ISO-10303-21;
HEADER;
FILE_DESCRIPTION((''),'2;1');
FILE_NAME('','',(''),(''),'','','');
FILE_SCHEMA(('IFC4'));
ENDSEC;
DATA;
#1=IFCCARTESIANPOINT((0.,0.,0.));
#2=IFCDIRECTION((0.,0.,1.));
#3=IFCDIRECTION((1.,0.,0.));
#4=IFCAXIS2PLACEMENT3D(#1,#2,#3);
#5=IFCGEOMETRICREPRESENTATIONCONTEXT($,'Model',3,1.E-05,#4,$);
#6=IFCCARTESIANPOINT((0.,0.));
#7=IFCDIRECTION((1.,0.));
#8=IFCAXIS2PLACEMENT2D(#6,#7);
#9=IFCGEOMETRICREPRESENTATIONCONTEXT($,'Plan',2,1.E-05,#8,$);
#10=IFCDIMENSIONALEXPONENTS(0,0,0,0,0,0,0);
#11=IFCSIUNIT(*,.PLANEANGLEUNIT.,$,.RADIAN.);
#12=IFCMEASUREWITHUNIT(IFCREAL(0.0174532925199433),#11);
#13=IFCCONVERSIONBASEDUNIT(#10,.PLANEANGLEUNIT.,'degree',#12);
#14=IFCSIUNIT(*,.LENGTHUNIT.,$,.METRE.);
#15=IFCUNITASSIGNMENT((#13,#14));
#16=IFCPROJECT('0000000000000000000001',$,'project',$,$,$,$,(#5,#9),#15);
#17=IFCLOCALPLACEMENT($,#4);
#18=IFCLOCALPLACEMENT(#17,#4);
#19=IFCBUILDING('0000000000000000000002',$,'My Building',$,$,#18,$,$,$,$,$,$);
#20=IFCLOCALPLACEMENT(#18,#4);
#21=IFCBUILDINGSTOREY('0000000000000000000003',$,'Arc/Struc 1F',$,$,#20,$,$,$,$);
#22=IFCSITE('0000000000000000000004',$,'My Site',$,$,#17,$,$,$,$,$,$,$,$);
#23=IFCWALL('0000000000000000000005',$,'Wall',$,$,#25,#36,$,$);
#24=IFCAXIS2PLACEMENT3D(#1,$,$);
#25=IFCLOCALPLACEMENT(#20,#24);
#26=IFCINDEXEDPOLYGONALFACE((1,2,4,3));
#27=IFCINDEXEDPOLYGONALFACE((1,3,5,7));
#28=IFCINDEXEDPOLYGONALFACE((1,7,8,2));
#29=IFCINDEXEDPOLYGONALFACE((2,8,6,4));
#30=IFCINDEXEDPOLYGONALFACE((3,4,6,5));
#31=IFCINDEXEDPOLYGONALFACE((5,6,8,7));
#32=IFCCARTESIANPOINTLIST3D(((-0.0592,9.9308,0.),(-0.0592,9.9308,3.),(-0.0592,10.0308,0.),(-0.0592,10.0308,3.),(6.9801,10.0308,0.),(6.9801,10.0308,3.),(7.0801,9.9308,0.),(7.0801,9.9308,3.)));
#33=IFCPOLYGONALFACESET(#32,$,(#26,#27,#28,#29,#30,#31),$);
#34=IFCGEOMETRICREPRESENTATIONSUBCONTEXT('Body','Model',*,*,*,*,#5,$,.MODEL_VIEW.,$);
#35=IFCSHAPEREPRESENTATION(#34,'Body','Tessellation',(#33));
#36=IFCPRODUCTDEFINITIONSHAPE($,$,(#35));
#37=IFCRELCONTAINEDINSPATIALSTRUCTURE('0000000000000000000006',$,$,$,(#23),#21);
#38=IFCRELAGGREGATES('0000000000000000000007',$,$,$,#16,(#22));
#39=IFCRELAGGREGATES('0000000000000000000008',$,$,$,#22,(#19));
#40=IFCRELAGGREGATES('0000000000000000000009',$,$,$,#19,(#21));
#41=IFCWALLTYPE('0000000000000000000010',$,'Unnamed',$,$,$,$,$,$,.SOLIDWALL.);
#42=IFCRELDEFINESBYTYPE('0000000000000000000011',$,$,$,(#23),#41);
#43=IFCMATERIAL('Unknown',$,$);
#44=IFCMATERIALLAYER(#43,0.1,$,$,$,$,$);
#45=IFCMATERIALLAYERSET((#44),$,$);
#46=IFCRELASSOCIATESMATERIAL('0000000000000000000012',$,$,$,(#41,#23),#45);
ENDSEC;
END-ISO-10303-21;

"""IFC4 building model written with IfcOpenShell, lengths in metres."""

from ifc_helpers import new_model, entity, si_unit, converted_unit, frame, origin_with_axes, origin_2d_with_axis, place, context, subcontext, project, spatial, line, indexed_curve, outline, extrude, material, layer, layer_set, layer_usage, type_object, element, save


model = new_model("IFC4")

# Units and contexts
model_context = context("Model", 3, precision=1e-05, world=origin_with_axes())
plan_context = context("Plan", 2, precision=1e-05, world=origin_2d_with_axis())
body_context_1 = subcontext(model_context, "Body", "Model", "MODEL_VIEW")
ifc_project = project(units=[converted_unit("PLANEANGLEUNIT", "degree", entity("IfcReal", 0.0174532925199433), si_unit("PLANEANGLEUNIT", "RADIAN"), dimensions=[0, 0, 0, 0, 0, 0, 0]), si_unit("LENGTHUNIT", "METRE")], contexts=[model_context, plan_context])

# Site, building, storey
site_placement = place(None, origin_with_axes())
site = spatial("IfcSite", under=ifc_project, at=site_placement, Name="My Site")
building_placement = place(site_placement, origin_with_axes())
building = spatial("IfcBuilding", under=site, at=building_placement, Name="My Building")
storey_placement = place(building_placement, origin_with_axes())
storey = spatial("IfcBuildingStorey", under=building, at=storey_placement, Name="Arc/Struc 1F")

# Shared definitions
ifc_material = material(Name="Unknown")

# Shared definitions
ifc_layer = layer(ifc_material, 0.1)
ifc_layer_set = layer_set([ifc_layer])
wall_type = type_object("IfcWallType", Name="Unnamed", PredefinedType="SOLIDWALL", material=ifc_layer_set)

# Wall
ifc_layer_usage_1 = layer_usage(ifc_layer_set, "AXIS2", "POSITIVE", 0.0)
wall_1_placement = place(storey_placement, frame((6.9801, 10.0308, 0.0), z_axis=(0.0, 0.0, 1.0), x_axis=(-1.0, 0.0, 0.0)))
element("IfcWall", 1, at=wall_1_placement, inside=storey, type_object=wall_type, material=ifc_layer_usage_1, Name="Wall", context=body_context_1, shape_type="SweptSolid", body=[
    extrude(outline(indexed_curve([(0.0, 0.0), (-0.1, 0.1), (7.0393, 0.1), (7.0393, 0.0)], segments=[line(1, 2, 3, 4, 1)])), origin_with_axes(), (0.0, 0.0, 1.0), 3.0),
])

save(model, "model.ifc")
